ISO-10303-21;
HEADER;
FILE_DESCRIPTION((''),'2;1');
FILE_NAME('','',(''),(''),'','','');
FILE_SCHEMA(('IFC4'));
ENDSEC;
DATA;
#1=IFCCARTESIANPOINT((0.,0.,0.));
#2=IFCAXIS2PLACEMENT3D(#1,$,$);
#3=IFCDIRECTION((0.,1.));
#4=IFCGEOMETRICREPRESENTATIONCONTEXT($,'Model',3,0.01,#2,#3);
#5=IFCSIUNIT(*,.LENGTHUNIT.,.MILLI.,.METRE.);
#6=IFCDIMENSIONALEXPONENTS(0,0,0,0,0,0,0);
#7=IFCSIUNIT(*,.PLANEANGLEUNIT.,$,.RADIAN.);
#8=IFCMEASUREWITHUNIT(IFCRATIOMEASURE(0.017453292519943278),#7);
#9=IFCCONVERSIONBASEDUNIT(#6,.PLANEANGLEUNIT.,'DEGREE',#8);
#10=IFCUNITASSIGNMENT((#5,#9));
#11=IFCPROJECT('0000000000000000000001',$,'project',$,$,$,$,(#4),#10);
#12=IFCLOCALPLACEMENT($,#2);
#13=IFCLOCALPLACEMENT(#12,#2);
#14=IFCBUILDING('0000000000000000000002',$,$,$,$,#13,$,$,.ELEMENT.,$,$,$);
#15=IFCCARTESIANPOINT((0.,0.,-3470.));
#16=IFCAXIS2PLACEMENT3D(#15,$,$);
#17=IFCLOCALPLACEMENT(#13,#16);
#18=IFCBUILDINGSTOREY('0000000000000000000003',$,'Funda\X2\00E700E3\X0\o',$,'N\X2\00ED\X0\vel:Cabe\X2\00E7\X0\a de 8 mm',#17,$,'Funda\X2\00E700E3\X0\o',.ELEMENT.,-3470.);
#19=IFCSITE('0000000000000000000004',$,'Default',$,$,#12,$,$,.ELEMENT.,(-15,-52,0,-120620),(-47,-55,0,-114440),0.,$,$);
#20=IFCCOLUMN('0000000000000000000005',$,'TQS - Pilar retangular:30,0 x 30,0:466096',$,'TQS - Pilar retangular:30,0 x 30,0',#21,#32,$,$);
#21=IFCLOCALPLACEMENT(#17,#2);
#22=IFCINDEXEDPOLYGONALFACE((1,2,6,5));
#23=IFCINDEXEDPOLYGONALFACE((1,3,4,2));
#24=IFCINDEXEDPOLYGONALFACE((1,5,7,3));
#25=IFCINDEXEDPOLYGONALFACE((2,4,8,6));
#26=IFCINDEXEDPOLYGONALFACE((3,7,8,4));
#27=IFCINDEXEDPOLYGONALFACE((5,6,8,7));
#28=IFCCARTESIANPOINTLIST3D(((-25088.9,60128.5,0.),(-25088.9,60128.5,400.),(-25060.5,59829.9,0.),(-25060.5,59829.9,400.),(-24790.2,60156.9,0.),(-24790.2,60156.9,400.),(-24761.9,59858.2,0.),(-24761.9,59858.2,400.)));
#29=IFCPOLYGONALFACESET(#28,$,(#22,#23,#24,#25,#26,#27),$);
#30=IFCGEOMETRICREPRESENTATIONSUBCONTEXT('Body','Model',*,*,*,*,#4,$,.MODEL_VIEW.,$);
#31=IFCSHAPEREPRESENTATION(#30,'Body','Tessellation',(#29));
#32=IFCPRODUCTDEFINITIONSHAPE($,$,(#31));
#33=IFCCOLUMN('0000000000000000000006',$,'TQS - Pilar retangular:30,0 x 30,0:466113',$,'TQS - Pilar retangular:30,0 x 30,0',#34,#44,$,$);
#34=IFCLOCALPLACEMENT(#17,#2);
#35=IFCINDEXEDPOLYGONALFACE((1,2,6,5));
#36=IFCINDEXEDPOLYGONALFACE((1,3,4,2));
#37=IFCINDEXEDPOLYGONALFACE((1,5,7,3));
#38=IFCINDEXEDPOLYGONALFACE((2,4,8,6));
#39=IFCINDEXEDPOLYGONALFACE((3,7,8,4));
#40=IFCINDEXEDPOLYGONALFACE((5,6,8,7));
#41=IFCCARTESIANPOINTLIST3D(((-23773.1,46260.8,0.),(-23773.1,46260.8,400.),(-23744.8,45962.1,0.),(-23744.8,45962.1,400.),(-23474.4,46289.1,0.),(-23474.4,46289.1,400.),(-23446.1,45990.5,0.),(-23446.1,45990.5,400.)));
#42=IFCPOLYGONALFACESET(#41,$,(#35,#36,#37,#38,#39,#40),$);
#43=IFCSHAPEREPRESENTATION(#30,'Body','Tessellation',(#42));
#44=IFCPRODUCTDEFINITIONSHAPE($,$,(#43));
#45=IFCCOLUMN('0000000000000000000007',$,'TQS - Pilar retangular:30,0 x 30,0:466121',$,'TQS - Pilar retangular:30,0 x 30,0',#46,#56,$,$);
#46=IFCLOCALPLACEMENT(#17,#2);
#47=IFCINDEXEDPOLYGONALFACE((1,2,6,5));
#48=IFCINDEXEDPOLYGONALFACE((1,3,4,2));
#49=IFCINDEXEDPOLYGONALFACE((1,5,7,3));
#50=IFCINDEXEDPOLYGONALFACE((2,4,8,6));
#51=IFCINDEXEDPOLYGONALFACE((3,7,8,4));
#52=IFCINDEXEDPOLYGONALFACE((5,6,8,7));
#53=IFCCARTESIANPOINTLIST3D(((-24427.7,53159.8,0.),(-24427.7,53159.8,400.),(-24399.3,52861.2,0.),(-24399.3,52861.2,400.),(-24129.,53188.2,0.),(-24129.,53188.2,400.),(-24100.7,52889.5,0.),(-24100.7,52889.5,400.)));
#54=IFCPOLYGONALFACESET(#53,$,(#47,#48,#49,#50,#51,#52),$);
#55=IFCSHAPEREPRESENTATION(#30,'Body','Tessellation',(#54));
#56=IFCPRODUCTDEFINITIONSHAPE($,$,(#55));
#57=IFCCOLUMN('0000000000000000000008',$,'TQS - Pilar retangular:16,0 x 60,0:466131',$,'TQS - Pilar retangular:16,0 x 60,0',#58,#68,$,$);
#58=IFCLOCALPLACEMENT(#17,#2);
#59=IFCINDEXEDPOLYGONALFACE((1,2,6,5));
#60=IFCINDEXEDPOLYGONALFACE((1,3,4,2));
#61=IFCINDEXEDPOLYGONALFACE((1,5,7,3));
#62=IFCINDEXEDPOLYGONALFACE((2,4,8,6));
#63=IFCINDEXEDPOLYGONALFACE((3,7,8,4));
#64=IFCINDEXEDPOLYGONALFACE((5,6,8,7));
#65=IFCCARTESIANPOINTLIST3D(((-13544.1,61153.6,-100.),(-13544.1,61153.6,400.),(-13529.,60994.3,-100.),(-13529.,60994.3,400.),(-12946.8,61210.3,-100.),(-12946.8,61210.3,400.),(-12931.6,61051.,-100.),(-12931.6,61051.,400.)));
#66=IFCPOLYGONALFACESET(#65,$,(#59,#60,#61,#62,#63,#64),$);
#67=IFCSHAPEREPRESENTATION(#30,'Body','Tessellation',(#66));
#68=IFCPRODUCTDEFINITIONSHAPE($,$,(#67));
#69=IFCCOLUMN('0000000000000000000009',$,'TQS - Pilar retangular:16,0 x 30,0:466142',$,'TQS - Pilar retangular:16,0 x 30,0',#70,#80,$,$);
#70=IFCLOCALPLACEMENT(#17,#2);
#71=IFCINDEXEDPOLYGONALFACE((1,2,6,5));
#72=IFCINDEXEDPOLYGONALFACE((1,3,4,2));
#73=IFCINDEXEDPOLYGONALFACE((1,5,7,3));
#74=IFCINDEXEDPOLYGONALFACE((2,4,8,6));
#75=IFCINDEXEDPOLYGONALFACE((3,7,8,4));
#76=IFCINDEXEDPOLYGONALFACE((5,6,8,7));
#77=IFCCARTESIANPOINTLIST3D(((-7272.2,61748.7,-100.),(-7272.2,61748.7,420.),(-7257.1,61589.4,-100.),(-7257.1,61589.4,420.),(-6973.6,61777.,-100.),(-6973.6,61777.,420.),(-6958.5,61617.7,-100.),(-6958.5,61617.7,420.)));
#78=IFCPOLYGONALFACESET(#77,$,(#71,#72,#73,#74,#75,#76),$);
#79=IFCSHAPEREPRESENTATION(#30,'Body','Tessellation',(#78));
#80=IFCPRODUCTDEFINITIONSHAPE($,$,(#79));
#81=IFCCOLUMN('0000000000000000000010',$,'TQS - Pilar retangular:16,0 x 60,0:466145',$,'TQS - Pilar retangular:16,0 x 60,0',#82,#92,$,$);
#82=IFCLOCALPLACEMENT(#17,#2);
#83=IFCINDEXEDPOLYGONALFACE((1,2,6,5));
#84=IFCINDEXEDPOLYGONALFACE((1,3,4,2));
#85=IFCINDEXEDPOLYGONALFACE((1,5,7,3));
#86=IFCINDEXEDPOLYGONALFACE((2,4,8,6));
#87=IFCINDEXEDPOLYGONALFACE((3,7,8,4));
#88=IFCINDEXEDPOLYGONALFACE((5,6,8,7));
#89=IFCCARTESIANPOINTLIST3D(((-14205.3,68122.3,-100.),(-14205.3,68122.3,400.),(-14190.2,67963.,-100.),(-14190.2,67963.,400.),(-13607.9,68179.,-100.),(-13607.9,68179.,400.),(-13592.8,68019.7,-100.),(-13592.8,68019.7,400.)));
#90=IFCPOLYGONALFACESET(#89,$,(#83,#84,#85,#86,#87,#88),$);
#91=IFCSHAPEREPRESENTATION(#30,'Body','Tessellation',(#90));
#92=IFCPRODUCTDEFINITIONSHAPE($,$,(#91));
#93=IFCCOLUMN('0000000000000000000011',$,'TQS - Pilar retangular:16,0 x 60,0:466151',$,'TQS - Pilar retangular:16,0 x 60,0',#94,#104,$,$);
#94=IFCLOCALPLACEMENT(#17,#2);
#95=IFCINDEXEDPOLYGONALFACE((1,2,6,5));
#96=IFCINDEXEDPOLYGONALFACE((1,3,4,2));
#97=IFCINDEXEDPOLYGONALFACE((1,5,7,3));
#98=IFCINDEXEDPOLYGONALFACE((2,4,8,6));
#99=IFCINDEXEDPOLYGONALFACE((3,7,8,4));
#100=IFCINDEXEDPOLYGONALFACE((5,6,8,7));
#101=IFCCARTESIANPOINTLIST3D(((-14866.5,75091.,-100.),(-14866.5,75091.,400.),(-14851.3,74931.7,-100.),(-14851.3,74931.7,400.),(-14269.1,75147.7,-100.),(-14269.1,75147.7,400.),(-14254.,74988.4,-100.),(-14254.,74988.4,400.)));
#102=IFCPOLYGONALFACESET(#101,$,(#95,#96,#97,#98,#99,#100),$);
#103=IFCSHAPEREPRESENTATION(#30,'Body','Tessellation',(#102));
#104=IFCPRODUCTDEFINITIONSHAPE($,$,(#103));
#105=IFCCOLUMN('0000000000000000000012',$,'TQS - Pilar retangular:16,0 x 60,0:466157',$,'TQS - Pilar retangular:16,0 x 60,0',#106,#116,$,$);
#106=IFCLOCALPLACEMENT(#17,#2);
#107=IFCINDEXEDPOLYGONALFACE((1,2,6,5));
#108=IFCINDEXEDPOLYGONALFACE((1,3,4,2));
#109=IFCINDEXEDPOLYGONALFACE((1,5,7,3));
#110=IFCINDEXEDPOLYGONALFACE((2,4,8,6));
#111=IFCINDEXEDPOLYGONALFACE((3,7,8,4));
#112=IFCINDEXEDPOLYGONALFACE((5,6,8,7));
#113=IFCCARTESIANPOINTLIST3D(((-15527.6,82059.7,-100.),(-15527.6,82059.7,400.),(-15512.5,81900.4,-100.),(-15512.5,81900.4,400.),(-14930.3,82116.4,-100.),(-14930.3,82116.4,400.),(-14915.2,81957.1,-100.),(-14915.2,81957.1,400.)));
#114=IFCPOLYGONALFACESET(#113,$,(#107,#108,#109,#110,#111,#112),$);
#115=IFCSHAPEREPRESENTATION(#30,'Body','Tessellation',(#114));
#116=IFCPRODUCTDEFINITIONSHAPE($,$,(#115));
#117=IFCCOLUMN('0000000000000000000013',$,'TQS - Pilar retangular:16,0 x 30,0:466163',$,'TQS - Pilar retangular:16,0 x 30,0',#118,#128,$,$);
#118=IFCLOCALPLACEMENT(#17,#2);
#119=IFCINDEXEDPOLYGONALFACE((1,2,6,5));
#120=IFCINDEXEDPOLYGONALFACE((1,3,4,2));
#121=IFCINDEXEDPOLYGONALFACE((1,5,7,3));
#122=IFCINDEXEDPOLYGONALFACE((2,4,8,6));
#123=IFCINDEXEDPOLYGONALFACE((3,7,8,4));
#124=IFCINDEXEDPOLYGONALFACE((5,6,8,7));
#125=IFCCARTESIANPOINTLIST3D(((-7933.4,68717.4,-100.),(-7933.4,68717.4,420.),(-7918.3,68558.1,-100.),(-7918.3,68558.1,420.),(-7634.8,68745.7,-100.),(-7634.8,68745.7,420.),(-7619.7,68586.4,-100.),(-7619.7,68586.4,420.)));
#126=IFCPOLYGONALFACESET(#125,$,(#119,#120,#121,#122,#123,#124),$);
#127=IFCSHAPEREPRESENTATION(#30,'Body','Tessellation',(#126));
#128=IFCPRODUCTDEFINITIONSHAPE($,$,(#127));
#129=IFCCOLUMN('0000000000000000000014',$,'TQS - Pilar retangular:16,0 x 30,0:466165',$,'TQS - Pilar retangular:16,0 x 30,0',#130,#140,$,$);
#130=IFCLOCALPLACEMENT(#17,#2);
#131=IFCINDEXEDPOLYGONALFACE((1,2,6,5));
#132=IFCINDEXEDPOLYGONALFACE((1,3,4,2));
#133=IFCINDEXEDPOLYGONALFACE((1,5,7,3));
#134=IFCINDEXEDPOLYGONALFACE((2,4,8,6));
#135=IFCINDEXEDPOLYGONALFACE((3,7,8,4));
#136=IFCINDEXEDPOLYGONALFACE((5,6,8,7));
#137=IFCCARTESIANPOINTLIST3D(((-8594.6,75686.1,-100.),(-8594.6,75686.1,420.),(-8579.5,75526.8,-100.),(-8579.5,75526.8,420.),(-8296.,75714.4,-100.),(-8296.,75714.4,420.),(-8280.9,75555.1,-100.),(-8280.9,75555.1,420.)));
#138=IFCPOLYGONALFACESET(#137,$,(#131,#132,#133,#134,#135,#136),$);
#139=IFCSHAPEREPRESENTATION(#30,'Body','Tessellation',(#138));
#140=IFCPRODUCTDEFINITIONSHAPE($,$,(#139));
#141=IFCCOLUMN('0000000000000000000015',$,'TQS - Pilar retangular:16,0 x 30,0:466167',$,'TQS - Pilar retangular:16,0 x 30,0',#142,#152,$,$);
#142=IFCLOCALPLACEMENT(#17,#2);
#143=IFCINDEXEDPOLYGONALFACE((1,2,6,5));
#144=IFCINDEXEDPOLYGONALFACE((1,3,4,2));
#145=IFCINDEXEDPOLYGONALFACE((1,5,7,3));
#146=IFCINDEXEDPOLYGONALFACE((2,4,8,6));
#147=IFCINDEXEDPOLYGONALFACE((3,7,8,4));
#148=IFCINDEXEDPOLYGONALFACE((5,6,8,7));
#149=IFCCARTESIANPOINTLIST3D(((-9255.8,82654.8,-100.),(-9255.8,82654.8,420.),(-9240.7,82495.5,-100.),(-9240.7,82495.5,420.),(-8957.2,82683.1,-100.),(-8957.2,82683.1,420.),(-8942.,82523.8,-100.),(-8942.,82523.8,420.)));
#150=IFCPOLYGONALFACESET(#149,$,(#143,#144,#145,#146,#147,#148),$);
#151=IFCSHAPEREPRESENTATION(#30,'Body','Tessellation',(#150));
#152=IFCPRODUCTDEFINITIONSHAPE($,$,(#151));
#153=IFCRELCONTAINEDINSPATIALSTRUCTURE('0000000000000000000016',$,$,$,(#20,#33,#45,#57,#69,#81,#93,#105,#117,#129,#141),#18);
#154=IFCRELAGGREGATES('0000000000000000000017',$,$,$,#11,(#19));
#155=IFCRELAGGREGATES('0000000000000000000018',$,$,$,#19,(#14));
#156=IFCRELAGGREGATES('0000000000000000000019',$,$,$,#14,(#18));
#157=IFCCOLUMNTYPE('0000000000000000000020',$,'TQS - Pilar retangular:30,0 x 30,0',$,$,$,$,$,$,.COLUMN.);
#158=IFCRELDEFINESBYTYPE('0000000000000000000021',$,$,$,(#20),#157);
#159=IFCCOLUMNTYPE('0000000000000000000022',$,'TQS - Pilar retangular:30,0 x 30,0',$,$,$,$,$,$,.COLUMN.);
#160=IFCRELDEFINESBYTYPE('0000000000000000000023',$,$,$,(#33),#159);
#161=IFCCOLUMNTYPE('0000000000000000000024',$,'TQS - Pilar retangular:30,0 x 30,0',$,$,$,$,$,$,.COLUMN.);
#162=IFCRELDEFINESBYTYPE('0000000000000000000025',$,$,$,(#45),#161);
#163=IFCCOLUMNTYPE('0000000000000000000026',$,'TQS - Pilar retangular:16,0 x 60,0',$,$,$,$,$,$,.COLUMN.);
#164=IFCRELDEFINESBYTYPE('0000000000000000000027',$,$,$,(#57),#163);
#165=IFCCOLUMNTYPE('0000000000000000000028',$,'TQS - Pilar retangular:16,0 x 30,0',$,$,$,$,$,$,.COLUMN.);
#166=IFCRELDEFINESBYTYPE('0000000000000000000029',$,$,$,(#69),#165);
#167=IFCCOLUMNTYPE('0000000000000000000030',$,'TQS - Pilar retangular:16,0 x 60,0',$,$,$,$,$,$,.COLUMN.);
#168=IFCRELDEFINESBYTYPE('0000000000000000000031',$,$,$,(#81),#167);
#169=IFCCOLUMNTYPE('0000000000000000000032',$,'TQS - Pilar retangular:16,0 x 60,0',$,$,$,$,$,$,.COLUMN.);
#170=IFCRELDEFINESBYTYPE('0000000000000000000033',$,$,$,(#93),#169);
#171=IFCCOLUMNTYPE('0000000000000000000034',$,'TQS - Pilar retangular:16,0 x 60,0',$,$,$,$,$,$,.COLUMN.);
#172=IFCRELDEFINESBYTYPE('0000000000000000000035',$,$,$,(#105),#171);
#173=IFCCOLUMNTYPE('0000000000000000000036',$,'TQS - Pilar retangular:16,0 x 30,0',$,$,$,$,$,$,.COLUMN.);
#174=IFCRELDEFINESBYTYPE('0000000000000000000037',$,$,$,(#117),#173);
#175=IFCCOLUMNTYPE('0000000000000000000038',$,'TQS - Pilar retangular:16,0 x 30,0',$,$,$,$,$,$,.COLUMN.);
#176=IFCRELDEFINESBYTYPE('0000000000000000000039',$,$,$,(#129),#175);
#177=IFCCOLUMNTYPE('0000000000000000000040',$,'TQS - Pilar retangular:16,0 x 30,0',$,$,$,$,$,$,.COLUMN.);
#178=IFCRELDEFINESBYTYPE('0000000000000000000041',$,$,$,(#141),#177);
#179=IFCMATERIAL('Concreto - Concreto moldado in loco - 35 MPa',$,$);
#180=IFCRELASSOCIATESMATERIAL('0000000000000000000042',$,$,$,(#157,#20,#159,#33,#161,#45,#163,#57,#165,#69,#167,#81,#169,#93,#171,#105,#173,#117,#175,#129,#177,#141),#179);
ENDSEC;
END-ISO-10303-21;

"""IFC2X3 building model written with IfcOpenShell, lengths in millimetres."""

from ifc_helpers import new_model, entity, si_unit, converted_unit, direction, frame, frame_2d, origin, origin_2d_with_axis, place, context, subcontext, project, spatial, rectangle, extrude, source, transform, mapped, material, type_object, type_shapes, element, save


model = new_model("IFC2X3")

# Units and contexts
model_context = context("Model", 3, precision=0.01, world=origin(), true_north=direction((0.0, 1.0)))
body_context = subcontext(model_context, "Body", "Model", "MODEL_VIEW")
ifc_project = project(units=[si_unit("LENGTHUNIT", "METRE", prefix="MILLI"), converted_unit("PLANEANGLEUNIT", "DEGREE", entity("IfcRatioMeasure", 0.017453292519943278), si_unit("PLANEANGLEUNIT", "RADIAN"), dimensions=[0, 0, 0, 0, 0, 0, 0])], contexts=[model_context])

# Site, building, storey
site_placement = place(None, origin())
site = spatial("IfcSite", under=ifc_project, at=site_placement, Name="Default", CompositionType="ELEMENT", RefLatitude=(-15, -52, 0, -120620), RefLongitude=(-47, -55, 0, -114440), RefElevation=0.0)
building_placement = place(site_placement, origin())
building = spatial("IfcBuilding", under=site, at=building_placement, CompositionType="ELEMENT")
storey_placement = place(building_placement, frame((0.0, 0.0, -3470.0)))
storey = spatial("IfcBuildingStorey", under=building, at=storey_placement, Name="Fundação", ObjectType="Nível:Cabeça de 8 mm", LongName="Fundação", CompositionType="ELEMENT", Elevation=-3470.0)

# Columns
ifc_material_1 = material(Name="Concreto - Concreto moldado in loco - 35 MPa")
column_type_1 = type_object("IfcColumnType", Name="TQS - Pilar retangular:30,0 x 30,0", PredefinedType="COLUMN", material=ifc_material_1)
shared_shape_1 = source(origin(), body_context, "Body", "SweptSolid", [
    extrude(rectangle(XDim=300.0, YDim=300.0, at=origin_2d_with_axis()), frame((-24925.4, 59993.4, -3470.0), z_axis=(0.0, 0.0, 1.0), x_axis=(-0.995529, -0.094456, 0.0)), (0.0, 0.0, 1.0), 400.0),
])
type_shapes(column_type_1, [shared_shape_1])
column_1_placement = place(storey_placement, frame((0.0, 0.0, 3470.0)))
element("IfcColumn", 1, at=column_1_placement, inside=storey, type_object=column_type_1, material=ifc_material_1, Name="TQS - Pilar retangular:30,0 x 30,0:466096", ObjectType="TQS - Pilar retangular:30,0 x 30,0", context=body_context, shape_type="MappedRepresentation", body=[
    mapped(shared_shape_1, transform((0.0, 0.0, 0.0), scale=1.0)),
])
column_type_2 = type_object("IfcColumnType", Name="TQS - Pilar retangular:30,0 x 30,0", PredefinedType="COLUMN", material=ifc_material_1)
shared_shape_2 = source(origin(), body_context, "Body", "SweptSolid", [
    extrude(rectangle(XDim=300.0, YDim=300.0, at=origin_2d_with_axis()), frame((-23609.6, 46125.6, -3470.0), z_axis=(0.0, 0.0, 1.0), x_axis=(-0.995529, -0.094456, 0.0)), (0.0, 0.0, 1.0), 400.0),
])
type_shapes(column_type_2, [shared_shape_2])
column_2_placement = place(storey_placement, frame((0.0, 0.0, 3470.0)))
element("IfcColumn", 2, at=column_2_placement, inside=storey, type_object=column_type_2, material=ifc_material_1, Name="TQS - Pilar retangular:30,0 x 30,0:466113", ObjectType="TQS - Pilar retangular:30,0 x 30,0", context=body_context, shape_type="MappedRepresentation", body=[
    mapped(shared_shape_2, transform((0.0, 0.0, 0.0), scale=1.0)),
])
column_type_3 = type_object("IfcColumnType", Name="TQS - Pilar retangular:30,0 x 30,0", PredefinedType="COLUMN", material=ifc_material_1)
shared_shape_3 = source(origin(), body_context, "Body", "SweptSolid", [
    extrude(rectangle(XDim=300.0, YDim=300.0, at=origin_2d_with_axis()), frame((-24264.2, 53024.7, -3470.0), z_axis=(0.0, 0.0, 1.0), x_axis=(-0.995529, -0.094456, 0.0)), (0.0, 0.0, 1.0), 400.0),
])
type_shapes(column_type_3, [shared_shape_3])
column_3_placement = place(storey_placement, frame((0.0, 0.0, 3470.0)))
element("IfcColumn", 3, at=column_3_placement, inside=storey, type_object=column_type_3, material=ifc_material_1, Name="TQS - Pilar retangular:30,0 x 30,0:466121", ObjectType="TQS - Pilar retangular:30,0 x 30,0", context=body_context, shape_type="MappedRepresentation", body=[
    mapped(shared_shape_3, transform((0.0, 0.0, 0.0), scale=1.0)),
])
column_type_4 = type_object("IfcColumnType", Name="TQS - Pilar retangular:16,0 x 60,0", PredefinedType="COLUMN", material=ifc_material_1)
shared_shape_4 = source(origin(), body_context, "Body", "SweptSolid", [
    extrude(rectangle(XDim=600.0, YDim=160.0, at=frame_2d((0.0, 0.0), x_axis=(1.0, 0.0))), frame((-13237.9, 61102.3, -3570.0), z_axis=(0.0, 0.0, 1.0), x_axis=(-0.995529, -0.094456, 0.0)), (0.0, 0.0, 1.0), 500.0),
])
type_shapes(column_type_4, [shared_shape_4])
column_4_placement = place(storey_placement, frame((0.0, 0.0, 3470.0)))
element("IfcColumn", 4, at=column_4_placement, inside=storey, type_object=column_type_4, material=ifc_material_1, Name="TQS - Pilar retangular:16,0 x 60,0:466131", ObjectType="TQS - Pilar retangular:16,0 x 60,0", context=body_context, shape_type="MappedRepresentation", body=[
    mapped(shared_shape_4, transform((0.0, 0.0, 0.0), scale=1.0)),
])
column_type_5 = type_object("IfcColumnType", Name="TQS - Pilar retangular:16,0 x 30,0", PredefinedType="COLUMN", material=ifc_material_1)
shared_shape_5 = source(origin(), body_context, "Body", "SweptSolid", [
    extrude(rectangle(XDim=300.0, YDim=160.0, at=frame_2d((0.0, 0.0), x_axis=(1.0, 0.0))), frame((-7115.4, 61683.2, -3570.0), z_axis=(0.0, 0.0, 1.0), x_axis=(-0.995529, -0.094456, 0.0)), (0.0, 0.0, 1.0), 520.0),
])
type_shapes(column_type_5, [shared_shape_5])
column_5_placement = place(storey_placement, frame((0.0, 0.0, 3470.0)))
element("IfcColumn", 5, at=column_5_placement, inside=storey, type_object=column_type_5, material=ifc_material_1, Name="TQS - Pilar retangular:16,0 x 30,0:466142", ObjectType="TQS - Pilar retangular:16,0 x 30,0", context=body_context, shape_type="MappedRepresentation", body=[
    mapped(shared_shape_5, transform((0.0, 0.0, 0.0), scale=1.0)),
])
column_type_6 = type_object("IfcColumnType", Name="TQS - Pilar retangular:16,0 x 60,0", PredefinedType="COLUMN", material=ifc_material_1)
shared_shape_6 = source(origin(), body_context, "Body", "SweptSolid", [
    extrude(rectangle(XDim=600.0, YDim=160.0, at=frame_2d((0.0, 0.0), x_axis=(1.0, 0.0))), frame((-13899.1, 68071.0, -3570.0), z_axis=(0.0, 0.0, 1.0), x_axis=(-0.995529, -0.094456, 0.0)), (0.0, 0.0, 1.0), 500.0),
])
type_shapes(column_type_6, [shared_shape_6])
column_6_placement = place(storey_placement, frame((0.0, 0.0, 3470.0)))
element("IfcColumn", 6, at=column_6_placement, inside=storey, type_object=column_type_6, material=ifc_material_1, Name="TQS - Pilar retangular:16,0 x 60,0:466145", ObjectType="TQS - Pilar retangular:16,0 x 60,0", context=body_context, shape_type="MappedRepresentation", body=[
    mapped(shared_shape_6, transform((0.0, 0.0, 0.0), scale=1.0)),
])
column_type_7 = type_object("IfcColumnType", Name="TQS - Pilar retangular:16,0 x 60,0", PredefinedType="COLUMN", material=ifc_material_1)
shared_shape_7 = source(origin(), body_context, "Body", "SweptSolid", [
    extrude(rectangle(XDim=600.0, YDim=160.0, at=frame_2d((0.0, 0.0), x_axis=(1.0, 0.0))), frame((-14560.2, 75039.7, -3570.0), z_axis=(0.0, 0.0, 1.0), x_axis=(-0.995529, -0.094456, 0.0)), (0.0, 0.0, 1.0), 500.0),
])
type_shapes(column_type_7, [shared_shape_7])
column_7_placement = place(storey_placement, frame((0.0, 0.0, 3470.0)))
element("IfcColumn", 7, at=column_7_placement, inside=storey, type_object=column_type_7, material=ifc_material_1, Name="TQS - Pilar retangular:16,0 x 60,0:466151", ObjectType="TQS - Pilar retangular:16,0 x 60,0", context=body_context, shape_type="MappedRepresentation", body=[
    mapped(shared_shape_7, transform((0.0, 0.0, 0.0), scale=1.0)),
])
column_type_8 = type_object("IfcColumnType", Name="TQS - Pilar retangular:16,0 x 60,0", PredefinedType="COLUMN", material=ifc_material_1)
shared_shape_8 = source(origin(), body_context, "Body", "SweptSolid", [
    extrude(rectangle(XDim=600.0, YDim=160.0, at=frame_2d((0.0, 0.0), x_axis=(1.0, 0.0))), frame((-15221.4, 82008.4, -3570.0), z_axis=(0.0, 0.0, 1.0), x_axis=(-0.995529, -0.094456, 0.0)), (0.0, 0.0, 1.0), 500.0),
])
type_shapes(column_type_8, [shared_shape_8])
column_8_placement = place(storey_placement, frame((0.0, 0.0, 3470.0)))
element("IfcColumn", 8, at=column_8_placement, inside=storey, type_object=column_type_8, material=ifc_material_1, Name="TQS - Pilar retangular:16,0 x 60,0:466157", ObjectType="TQS - Pilar retangular:16,0 x 60,0", context=body_context, shape_type="MappedRepresentation", body=[
    mapped(shared_shape_8, transform((0.0, 0.0, 0.0), scale=1.0)),
])
column_type_9 = type_object("IfcColumnType", Name="TQS - Pilar retangular:16,0 x 30,0", PredefinedType="COLUMN", material=ifc_material_1)
shared_shape_9 = source(origin(), body_context, "Body", "SweptSolid", [
    extrude(rectangle(XDim=300.0, YDim=160.0, at=frame_2d((0.0, 0.0), x_axis=(1.0, 0.0))), frame((-7776.5, 68651.9, -3570.0), z_axis=(0.0, 0.0, 1.0), x_axis=(-0.995529, -0.094456, 0.0)), (0.0, 0.0, 1.0), 520.0),
])
type_shapes(column_type_9, [shared_shape_9])
column_9_placement = place(storey_placement, frame((0.0, 0.0, 3470.0)))
element("IfcColumn", 9, at=column_9_placement, inside=storey, type_object=column_type_9, material=ifc_material_1, Name="TQS - Pilar retangular:16,0 x 30,0:466163", ObjectType="TQS - Pilar retangular:16,0 x 30,0", context=body_context, shape_type="MappedRepresentation", body=[
    mapped(shared_shape_9, transform((0.0, 0.0, 0.0), scale=1.0)),
])
column_type_10 = type_object("IfcColumnType", Name="TQS - Pilar retangular:16,0 x 30,0", PredefinedType="COLUMN", material=ifc_material_1)
shared_shape_10 = source(origin(), body_context, "Body", "SweptSolid", [
    extrude(rectangle(XDim=300.0, YDim=160.0, at=frame_2d((0.0, 0.0), x_axis=(1.0, 0.0))), frame((-8437.7, 75620.6, -3570.0), z_axis=(0.0, 0.0, 1.0), x_axis=(-0.995529, -0.094456, 0.0)), (0.0, 0.0, 1.0), 520.0),
])
type_shapes(column_type_10, [shared_shape_10])
column_10_placement = place(storey_placement, frame((0.0, 0.0, 3470.0)))
element("IfcColumn", 10, at=column_10_placement, inside=storey, type_object=column_type_10, material=ifc_material_1, Name="TQS - Pilar retangular:16,0 x 30,0:466165", ObjectType="TQS - Pilar retangular:16,0 x 30,0", context=body_context, shape_type="MappedRepresentation", body=[
    mapped(shared_shape_10, transform((0.0, 0.0, 0.0), scale=1.0)),
])
column_type_11 = type_object("IfcColumnType", Name="TQS - Pilar retangular:16,0 x 30,0", PredefinedType="COLUMN", material=ifc_material_1)
shared_shape_11 = source(origin(), body_context, "Body", "SweptSolid", [
    extrude(rectangle(XDim=300.0, YDim=160.0, at=frame_2d((0.0, 0.0), x_axis=(1.0, 0.0))), frame((-9098.9, 82589.3, -3570.0), z_axis=(0.0, 0.0, 1.0), x_axis=(-0.995529, -0.094456, 0.0)), (0.0, 0.0, 1.0), 520.0),
])
type_shapes(column_type_11, [shared_shape_11])
column_11_placement = place(storey_placement, frame((0.0, 0.0, 3470.0)))
element("IfcColumn", 11, at=column_11_placement, inside=storey, type_object=column_type_11, material=ifc_material_1, Name="TQS - Pilar retangular:16,0 x 30,0:466167", ObjectType="TQS - Pilar retangular:16,0 x 30,0", context=body_context, shape_type="MappedRepresentation", body=[
    mapped(shared_shape_11, transform((0.0, 0.0, 0.0), scale=1.0)),
])

save(model, "model.ifc")
